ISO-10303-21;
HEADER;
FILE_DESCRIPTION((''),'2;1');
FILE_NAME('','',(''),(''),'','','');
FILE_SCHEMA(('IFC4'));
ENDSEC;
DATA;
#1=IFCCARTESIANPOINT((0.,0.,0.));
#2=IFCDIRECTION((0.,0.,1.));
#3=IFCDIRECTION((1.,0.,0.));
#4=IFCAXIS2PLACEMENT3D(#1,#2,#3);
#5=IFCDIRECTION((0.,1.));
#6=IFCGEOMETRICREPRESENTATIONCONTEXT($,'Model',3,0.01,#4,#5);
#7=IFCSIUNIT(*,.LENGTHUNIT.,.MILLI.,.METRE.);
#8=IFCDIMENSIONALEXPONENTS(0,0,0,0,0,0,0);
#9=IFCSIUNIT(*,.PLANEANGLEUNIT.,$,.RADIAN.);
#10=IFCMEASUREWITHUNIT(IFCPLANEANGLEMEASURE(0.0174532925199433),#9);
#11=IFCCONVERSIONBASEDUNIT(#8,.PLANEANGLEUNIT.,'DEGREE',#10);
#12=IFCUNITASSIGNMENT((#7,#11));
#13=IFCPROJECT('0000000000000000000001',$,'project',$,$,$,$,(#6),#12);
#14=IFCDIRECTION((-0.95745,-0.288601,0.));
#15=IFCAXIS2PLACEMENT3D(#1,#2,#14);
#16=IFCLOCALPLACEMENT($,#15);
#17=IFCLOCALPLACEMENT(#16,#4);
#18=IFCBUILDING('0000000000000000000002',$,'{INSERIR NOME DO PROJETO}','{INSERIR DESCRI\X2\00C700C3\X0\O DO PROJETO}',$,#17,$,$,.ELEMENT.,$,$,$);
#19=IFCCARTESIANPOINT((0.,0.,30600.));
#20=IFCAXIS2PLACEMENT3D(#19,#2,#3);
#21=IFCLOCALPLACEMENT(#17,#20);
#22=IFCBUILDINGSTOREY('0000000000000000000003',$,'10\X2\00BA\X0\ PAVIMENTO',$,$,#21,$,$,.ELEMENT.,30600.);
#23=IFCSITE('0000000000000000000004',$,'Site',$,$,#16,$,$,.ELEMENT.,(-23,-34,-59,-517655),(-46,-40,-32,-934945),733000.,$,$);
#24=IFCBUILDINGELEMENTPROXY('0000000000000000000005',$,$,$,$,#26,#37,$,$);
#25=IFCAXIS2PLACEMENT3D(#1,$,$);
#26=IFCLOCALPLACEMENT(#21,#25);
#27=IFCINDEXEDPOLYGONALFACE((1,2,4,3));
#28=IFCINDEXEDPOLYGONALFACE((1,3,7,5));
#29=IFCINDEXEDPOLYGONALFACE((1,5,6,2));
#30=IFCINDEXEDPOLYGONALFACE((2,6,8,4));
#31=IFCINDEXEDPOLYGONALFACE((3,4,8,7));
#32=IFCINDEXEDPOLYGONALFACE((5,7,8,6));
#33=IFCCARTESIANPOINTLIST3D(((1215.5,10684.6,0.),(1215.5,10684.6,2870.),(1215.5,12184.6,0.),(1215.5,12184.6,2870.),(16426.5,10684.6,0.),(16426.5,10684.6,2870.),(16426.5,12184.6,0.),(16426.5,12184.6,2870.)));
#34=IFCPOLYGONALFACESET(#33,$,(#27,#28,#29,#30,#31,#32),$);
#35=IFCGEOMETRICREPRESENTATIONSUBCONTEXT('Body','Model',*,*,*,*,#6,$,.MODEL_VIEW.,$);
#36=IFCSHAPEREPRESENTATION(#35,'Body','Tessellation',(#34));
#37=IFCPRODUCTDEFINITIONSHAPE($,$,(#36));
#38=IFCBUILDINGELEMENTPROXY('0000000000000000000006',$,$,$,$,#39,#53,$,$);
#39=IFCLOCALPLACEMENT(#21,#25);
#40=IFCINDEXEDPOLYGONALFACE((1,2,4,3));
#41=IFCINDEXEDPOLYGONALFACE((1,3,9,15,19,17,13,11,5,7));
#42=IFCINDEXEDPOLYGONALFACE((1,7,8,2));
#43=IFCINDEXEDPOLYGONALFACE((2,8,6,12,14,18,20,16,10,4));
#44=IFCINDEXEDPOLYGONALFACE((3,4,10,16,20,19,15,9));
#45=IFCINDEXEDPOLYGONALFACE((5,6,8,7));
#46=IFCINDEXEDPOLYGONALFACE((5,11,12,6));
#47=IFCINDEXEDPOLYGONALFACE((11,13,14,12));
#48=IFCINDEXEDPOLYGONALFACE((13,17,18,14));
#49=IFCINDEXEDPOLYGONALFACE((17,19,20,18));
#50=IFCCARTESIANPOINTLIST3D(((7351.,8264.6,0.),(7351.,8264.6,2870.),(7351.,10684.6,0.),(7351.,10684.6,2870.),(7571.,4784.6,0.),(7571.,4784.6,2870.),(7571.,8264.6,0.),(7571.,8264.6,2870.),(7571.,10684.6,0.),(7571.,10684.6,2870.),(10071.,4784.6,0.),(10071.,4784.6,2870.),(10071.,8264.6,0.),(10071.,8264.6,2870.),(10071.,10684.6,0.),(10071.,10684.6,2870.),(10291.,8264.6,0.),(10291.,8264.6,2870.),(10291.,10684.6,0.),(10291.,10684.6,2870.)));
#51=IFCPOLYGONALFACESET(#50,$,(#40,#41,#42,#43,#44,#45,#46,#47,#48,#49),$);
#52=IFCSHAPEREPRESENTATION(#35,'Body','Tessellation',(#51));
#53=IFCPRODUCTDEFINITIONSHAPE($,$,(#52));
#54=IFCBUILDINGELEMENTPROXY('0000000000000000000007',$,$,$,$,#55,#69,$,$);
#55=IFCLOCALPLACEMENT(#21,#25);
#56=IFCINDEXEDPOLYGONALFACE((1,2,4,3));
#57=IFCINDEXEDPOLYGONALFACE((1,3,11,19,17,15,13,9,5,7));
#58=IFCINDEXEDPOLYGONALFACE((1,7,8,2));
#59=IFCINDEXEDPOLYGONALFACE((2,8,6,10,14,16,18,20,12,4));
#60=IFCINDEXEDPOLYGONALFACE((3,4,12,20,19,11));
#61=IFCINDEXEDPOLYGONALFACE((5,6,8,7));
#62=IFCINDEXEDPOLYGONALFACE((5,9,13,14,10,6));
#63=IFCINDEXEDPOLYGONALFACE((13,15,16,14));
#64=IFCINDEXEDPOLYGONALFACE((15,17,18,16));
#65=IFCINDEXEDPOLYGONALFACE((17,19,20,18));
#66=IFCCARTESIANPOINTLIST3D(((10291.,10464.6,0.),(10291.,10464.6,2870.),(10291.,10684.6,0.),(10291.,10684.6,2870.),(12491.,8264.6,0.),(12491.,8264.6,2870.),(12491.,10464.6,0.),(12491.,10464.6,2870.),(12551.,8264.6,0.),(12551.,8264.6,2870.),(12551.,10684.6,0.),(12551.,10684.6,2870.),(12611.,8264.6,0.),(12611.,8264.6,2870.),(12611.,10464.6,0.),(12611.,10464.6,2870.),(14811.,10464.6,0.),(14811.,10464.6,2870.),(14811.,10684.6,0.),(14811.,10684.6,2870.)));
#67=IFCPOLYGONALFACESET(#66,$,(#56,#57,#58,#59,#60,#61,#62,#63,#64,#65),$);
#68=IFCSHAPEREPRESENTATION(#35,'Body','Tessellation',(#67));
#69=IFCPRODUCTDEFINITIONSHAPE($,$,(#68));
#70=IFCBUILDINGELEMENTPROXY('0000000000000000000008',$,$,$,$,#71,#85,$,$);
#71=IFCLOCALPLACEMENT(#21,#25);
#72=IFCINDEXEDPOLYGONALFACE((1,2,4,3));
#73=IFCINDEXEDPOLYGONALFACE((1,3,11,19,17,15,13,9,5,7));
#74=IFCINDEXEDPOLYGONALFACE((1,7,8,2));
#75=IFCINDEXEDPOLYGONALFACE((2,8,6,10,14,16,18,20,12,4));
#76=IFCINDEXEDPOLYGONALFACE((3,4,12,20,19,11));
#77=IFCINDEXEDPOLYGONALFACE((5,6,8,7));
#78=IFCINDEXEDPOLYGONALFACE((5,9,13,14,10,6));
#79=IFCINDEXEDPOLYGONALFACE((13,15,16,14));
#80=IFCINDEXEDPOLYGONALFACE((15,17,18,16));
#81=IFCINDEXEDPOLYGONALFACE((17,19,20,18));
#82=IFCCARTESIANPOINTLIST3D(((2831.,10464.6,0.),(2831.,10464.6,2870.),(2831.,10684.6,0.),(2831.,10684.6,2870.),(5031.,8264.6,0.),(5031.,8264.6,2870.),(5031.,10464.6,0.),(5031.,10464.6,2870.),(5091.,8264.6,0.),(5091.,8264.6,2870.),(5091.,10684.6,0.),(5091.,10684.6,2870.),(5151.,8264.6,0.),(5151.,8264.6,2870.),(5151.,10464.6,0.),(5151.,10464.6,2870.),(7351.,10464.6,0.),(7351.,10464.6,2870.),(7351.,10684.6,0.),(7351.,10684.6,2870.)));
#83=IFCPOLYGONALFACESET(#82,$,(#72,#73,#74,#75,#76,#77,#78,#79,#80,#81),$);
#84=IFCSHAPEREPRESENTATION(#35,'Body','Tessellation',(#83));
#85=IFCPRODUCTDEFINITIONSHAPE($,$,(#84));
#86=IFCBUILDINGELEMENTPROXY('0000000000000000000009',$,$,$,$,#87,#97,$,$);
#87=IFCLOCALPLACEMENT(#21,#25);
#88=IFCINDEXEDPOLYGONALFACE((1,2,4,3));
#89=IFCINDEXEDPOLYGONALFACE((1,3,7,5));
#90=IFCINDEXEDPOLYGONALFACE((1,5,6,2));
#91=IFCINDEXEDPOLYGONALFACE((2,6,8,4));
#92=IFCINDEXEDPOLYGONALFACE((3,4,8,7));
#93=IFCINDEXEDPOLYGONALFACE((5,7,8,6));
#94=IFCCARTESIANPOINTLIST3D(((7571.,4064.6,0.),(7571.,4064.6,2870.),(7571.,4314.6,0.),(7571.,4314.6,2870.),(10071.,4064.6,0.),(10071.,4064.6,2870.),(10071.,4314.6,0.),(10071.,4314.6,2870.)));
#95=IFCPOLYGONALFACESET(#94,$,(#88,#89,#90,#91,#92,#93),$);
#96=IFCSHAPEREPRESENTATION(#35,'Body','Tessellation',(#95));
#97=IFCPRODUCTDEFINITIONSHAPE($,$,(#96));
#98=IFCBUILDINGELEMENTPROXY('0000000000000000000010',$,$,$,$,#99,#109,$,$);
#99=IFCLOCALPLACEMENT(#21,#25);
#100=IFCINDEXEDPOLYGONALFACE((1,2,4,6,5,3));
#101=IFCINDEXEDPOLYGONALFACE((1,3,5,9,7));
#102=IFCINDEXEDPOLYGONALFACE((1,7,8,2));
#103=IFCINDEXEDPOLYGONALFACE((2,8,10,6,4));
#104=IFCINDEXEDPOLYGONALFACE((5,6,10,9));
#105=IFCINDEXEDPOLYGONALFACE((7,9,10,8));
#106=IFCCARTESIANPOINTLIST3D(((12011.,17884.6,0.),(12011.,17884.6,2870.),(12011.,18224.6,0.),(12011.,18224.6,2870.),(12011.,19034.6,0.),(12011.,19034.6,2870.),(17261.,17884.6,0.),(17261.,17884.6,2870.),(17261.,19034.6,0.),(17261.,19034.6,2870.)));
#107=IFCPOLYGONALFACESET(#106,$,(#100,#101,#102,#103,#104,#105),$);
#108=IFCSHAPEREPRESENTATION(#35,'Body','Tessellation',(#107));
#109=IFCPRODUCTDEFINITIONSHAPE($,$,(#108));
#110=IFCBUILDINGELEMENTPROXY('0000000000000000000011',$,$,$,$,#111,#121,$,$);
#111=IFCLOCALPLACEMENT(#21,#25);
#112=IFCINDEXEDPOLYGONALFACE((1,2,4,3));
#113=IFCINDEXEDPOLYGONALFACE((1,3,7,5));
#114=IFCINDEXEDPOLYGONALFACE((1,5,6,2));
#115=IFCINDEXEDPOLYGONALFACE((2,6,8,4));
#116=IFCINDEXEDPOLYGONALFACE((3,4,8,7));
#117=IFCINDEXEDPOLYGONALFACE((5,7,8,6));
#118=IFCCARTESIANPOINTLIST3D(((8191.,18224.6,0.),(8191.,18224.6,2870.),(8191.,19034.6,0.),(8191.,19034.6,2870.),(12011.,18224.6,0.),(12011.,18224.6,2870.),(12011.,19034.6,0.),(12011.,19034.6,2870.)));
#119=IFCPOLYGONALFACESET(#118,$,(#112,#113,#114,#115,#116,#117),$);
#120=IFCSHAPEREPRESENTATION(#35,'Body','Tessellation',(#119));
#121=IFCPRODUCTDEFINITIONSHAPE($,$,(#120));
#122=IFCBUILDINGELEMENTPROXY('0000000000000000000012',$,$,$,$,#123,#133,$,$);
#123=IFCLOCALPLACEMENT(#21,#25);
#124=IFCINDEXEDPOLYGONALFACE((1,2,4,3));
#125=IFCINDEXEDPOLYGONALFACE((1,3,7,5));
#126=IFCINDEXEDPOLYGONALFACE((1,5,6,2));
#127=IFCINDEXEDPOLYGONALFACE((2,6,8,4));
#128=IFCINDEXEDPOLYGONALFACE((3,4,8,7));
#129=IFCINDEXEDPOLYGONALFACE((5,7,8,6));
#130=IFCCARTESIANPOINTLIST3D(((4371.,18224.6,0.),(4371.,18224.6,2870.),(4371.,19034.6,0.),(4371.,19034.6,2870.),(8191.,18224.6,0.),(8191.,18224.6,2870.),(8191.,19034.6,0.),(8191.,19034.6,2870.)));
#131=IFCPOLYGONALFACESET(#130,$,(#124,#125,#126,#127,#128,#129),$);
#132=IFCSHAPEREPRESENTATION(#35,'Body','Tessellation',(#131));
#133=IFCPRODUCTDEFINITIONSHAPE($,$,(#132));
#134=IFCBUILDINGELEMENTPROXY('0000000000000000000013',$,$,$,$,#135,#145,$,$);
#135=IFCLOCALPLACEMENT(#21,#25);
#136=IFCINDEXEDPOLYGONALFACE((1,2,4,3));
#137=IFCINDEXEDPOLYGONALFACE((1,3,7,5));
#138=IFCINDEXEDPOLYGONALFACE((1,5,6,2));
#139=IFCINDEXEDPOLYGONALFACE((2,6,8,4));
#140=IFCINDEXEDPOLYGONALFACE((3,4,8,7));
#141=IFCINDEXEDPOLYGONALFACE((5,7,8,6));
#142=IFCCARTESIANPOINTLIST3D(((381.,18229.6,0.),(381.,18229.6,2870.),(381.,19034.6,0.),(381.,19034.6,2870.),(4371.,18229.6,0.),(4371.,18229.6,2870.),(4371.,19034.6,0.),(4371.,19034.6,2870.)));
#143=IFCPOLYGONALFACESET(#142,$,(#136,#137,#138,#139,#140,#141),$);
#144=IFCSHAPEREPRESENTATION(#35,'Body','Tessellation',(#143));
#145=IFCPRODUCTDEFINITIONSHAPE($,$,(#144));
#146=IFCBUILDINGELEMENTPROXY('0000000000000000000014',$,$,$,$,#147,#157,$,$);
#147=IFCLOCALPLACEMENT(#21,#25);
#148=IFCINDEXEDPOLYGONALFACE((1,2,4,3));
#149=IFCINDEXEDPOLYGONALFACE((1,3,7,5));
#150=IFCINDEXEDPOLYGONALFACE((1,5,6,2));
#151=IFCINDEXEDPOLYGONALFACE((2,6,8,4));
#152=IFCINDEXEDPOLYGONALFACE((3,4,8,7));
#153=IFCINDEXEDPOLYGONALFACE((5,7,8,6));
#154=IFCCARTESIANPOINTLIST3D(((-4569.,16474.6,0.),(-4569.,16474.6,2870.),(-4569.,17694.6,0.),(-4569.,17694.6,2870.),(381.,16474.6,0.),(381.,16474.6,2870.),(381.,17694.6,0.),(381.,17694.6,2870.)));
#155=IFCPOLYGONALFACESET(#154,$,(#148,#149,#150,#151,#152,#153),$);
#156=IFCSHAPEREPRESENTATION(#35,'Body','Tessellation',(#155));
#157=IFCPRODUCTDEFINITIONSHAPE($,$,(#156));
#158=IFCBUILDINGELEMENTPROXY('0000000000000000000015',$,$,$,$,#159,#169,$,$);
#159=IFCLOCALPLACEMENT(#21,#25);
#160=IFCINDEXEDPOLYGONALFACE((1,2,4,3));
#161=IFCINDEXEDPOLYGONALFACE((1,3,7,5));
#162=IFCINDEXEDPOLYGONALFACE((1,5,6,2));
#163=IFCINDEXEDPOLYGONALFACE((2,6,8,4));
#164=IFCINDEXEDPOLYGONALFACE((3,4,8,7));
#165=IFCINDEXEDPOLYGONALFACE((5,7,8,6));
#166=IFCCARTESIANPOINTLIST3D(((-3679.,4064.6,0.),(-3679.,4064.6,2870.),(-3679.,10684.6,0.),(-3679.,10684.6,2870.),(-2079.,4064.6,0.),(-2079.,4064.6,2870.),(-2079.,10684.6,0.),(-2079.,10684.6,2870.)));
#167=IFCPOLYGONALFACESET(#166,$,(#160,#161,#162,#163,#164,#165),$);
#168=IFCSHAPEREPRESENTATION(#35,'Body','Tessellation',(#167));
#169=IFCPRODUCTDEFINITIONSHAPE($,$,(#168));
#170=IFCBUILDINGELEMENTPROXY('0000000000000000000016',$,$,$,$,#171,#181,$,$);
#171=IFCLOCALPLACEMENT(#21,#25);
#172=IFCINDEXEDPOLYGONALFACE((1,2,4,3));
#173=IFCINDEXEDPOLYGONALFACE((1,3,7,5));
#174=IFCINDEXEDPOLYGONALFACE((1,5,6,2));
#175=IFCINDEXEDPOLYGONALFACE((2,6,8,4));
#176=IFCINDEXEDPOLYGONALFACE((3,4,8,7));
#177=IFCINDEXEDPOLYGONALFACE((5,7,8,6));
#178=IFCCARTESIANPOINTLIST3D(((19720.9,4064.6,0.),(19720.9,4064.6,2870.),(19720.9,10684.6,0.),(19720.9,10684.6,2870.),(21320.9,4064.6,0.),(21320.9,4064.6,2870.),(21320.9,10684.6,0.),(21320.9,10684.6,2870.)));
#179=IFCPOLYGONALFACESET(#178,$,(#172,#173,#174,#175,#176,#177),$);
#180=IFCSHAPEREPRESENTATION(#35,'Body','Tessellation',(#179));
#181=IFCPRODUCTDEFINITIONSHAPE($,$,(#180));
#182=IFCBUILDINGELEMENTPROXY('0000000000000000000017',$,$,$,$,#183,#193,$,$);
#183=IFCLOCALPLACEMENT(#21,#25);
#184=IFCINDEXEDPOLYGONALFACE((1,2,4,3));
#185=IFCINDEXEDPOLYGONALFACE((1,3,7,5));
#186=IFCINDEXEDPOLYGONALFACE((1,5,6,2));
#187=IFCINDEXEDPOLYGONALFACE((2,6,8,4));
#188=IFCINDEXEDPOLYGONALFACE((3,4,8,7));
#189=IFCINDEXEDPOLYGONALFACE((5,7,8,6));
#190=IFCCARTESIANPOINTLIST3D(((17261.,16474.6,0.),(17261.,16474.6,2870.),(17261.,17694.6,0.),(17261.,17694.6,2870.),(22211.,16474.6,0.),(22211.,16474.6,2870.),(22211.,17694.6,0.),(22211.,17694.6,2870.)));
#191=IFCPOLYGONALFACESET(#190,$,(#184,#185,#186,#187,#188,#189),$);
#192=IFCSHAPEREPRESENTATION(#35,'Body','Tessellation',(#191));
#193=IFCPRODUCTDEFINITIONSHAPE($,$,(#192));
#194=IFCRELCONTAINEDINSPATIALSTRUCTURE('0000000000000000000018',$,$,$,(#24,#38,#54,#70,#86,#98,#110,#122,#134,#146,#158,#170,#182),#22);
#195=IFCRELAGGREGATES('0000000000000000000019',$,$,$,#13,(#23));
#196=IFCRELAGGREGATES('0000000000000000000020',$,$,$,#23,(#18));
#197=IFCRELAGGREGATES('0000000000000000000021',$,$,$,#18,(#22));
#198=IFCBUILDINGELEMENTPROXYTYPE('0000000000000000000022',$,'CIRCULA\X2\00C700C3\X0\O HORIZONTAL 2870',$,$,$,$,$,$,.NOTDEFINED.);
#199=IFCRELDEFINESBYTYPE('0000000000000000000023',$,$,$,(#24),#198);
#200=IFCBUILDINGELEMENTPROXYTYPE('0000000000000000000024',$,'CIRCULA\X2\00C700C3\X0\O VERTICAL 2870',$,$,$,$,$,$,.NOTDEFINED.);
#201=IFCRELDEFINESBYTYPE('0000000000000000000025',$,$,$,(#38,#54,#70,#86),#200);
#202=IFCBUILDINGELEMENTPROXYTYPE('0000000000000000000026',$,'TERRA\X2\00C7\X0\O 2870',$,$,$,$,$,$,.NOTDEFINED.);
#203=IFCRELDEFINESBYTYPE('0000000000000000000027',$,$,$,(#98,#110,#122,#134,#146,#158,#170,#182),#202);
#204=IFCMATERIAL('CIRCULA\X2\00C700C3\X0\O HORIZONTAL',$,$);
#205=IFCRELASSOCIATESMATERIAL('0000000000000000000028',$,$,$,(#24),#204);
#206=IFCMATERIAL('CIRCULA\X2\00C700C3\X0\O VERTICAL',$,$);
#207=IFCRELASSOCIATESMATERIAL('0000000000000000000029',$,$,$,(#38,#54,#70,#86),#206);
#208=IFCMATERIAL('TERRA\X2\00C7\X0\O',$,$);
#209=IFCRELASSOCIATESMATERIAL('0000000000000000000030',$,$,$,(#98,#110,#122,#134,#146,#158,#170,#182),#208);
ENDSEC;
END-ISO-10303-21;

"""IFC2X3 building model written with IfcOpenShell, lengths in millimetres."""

from ifc_helpers import new_model, entity, si_unit, converted_unit, direction, frame, origin_with_axes, place, context, subcontext, project, spatial, polyline, outline, extrude, material, type_object, element, save


model = new_model("IFC2X3")

# Units and contexts
model_context = context("Model", 3, precision=0.01, world=origin_with_axes(), true_north=direction((0.0, 1.0)))
body_context = subcontext(model_context, "Body", "Model", "MODEL_VIEW")
ifc_project = project(units=[si_unit("LENGTHUNIT", "METRE", prefix="MILLI"), converted_unit("PLANEANGLEUNIT", "DEGREE", entity("IfcPlaneAngleMeasure", 0.0174532925199433), si_unit("PLANEANGLEUNIT", "RADIAN"), dimensions=[0, 0, 0, 0, 0, 0, 0])], contexts=[model_context])

# Site, building, storey
site_placement = place(None, frame((0.0, 0.0, 0.0), z_axis=(0.0, 0.0, 1.0), x_axis=(-0.95745, -0.288601, 0.0)))
site = spatial("IfcSite", under=ifc_project, at=site_placement, Name="Site", CompositionType="ELEMENT", RefLatitude=(-23, -34, -59, -517655), RefLongitude=(-46, -40, -32, -934945), RefElevation=733000.0)
building_placement = place(site_placement, origin_with_axes())
building = spatial("IfcBuilding", under=site, at=building_placement, Name="{INSERIR NOME DO PROJETO}", Description="{INSERIR DESCRIÇÃO DO PROJETO}", CompositionType="ELEMENT")
storey_placement = place(building_placement, frame((0.0, 0.0, 30600.0), z_axis=(0.0, 0.0, 1.0), x_axis=(1.0, 0.0, 0.0)))
storey = spatial("IfcBuildingStorey", under=building, at=storey_placement, Name="10º PAVIMENTO", CompositionType="ELEMENT", Elevation=30600.0)

# Building element proxies
ifc_material_1 = material(Name="CIRCULAÇÃO HORIZONTAL")
building_element_proxy_type_1 = type_object("IfcBuildingElementProxyType", Name="CIRCULAÇÃO HORIZONTAL 2870", PredefinedType="NOTDEFINED")
proxy_1_placement = place(storey_placement, frame((1215.5, 10684.6, 0.0), z_axis=(0.0, 0.0, 1.0), x_axis=(1.0, 0.0, 0.0)))
element("IfcBuildingElementProxy", 1, at=proxy_1_placement, inside=storey, type_object=building_element_proxy_type_1, material=ifc_material_1, context=body_context, shape_type="SweptSolid", body=[
    extrude(outline(polyline([(0.0, 0.0), (15211.0, 0.0), (15211.0, 1500.0), (0.0, 1500.0), (0.0, 0.0)])), origin_with_axes(), (0.0, 0.0, 1.0), 2870.0),
])
ifc_material_2 = material(Name="CIRCULAÇÃO VERTICAL")
building_element_proxy_type_2 = type_object("IfcBuildingElementProxyType", Name="CIRCULAÇÃO VERTICAL 2870", PredefinedType="NOTDEFINED")
proxy_2_placement = place(storey_placement, frame((7351.0, 10684.6, 0.0), z_axis=(0.0, 0.0, 1.0), x_axis=(1.0, 0.0, 0.0)))
element("IfcBuildingElementProxy", 2, at=proxy_2_placement, inside=storey, type_object=building_element_proxy_type_2, material=ifc_material_2, context=body_context, shape_type="SweptSolid", body=[
    extrude(outline(polyline([(0.0, 0.0), (0.0, -2420.0), (220.0, -2420.0), (220.0, -5900.0), (2720.0, -5900.0), (2720.0, -2420.0), (2940.0, -2420.0), (2940.0, 0.0), (2720.0, 0.0), (220.0, 0.0), (0.0, 0.0)])), origin_with_axes(), (0.0, 0.0, 1.0), 2870.0),
])
proxy_3_placement = place(storey_placement, frame((10291.0, 10684.6, 0.0), z_axis=(0.0, 0.0, 1.0), x_axis=(1.0, 0.0, 0.0)))
element("IfcBuildingElementProxy", 3, at=proxy_3_placement, inside=storey, type_object=building_element_proxy_type_2, material=ifc_material_2, context=body_context, shape_type="SweptSolid", body=[
    extrude(outline(polyline([(0.0, 0.0), (0.0, -220.0), (2200.0, -220.0), (2200.0, -2420.0), (2260.0, -2420.0), (2320.0, -2420.0), (2320.0, -220.0), (4520.0, -220.0), (4520.0, 0.0), (2260.0, 0.0), (0.0, 0.0)])), origin_with_axes(), (0.0, 0.0, 1.0), 2870.0),
])
proxy_4_placement = place(storey_placement, frame((5091.0, 10684.6, 0.0), z_axis=(0.0, 0.0, 1.0), x_axis=(1.0, 0.0, 0.0)))
element("IfcBuildingElementProxy", 4, at=proxy_4_placement, inside=storey, type_object=building_element_proxy_type_2, material=ifc_material_2, context=body_context, shape_type="SweptSolid", body=[
    extrude(outline(polyline([(0.0, 0.0), (-2260.0, 0.0), (-2260.0, -220.0), (-60.0, -220.0), (-60.0, -2420.0), (0.0, -2420.0), (60.0, -2420.0), (60.0, -220.0), (2260.0, -220.0), (2260.0, 0.0), (0.0, 0.0)])), origin_with_axes(), (0.0, 0.0, 1.0), 2870.0),
])
proxy_5_placement = place(storey_placement, frame((7571.0, 4064.6, 0.0), z_axis=(0.0, 0.0, 1.0), x_axis=(1.0, 0.0, 0.0)))
element("IfcBuildingElementProxy", 5, at=proxy_5_placement, inside=storey, type_object=building_element_proxy_type_2, material=ifc_material_2, context=body_context, shape_type="SweptSolid", body=[
    extrude(outline(polyline([(0.0, 0.0), (2500.0, 0.0), (2500.0, 250.0), (0.0, 250.0), (0.0, 0.0)])), origin_with_axes(), (0.0, 0.0, 1.0), 2870.0),
])
ifc_material_3 = material(Name="TERRAÇO")
building_element_proxy_type_3 = type_object("IfcBuildingElementProxyType", Name="TERRAÇO 2870", PredefinedType="NOTDEFINED")
proxy_6_placement = place(storey_placement, frame((12011.0, 19034.6, 0.0), z_axis=(0.0, 0.0, 1.0), x_axis=(1.0, 0.0, 0.0)))
element("IfcBuildingElementProxy", 6, at=proxy_6_placement, inside=storey, type_object=building_element_proxy_type_3, material=ifc_material_3, context=body_context, shape_type="SweptSolid", body=[
    extrude(outline(polyline([(0.0, 0.0), (0.0, -810.0), (0.0, -1150.0), (5250.0, -1150.0), (5250.0, 0.0), (0.0, 0.0)])), origin_with_axes(), (0.0, 0.0, 1.0), 2870.0),
])
for number, where, z_axis, x_axis in (
    (7, (8191.0, 18224.6, 0.0), (0.0, 0.0, 1.0), (1.0, 0.0, 0.0)),
    (8, (4371.0, 18224.6, 0.0), (0.0, 0.0, 1.0), (1.0, 0.0, 0.0)),
):
    element("IfcBuildingElementProxy", number, at=place(storey_placement, frame(where, z_axis=z_axis, x_axis=x_axis)), inside=storey, type_object=building_element_proxy_type_3, material=ifc_material_3, context=body_context, shape_type="SweptSolid", body=[
        extrude(outline(polyline([(0.0, 0.0), (3820.0, 0.0), (3820.0, 810.0), (0.0, 810.0), (0.0, 0.0)])), origin_with_axes(), (0.0, 0.0, 1.0), 2870.0),
    ])
proxy_7_placement = place(storey_placement, frame((381.0, 19034.6, 0.0), z_axis=(0.0, 0.0, 1.0), x_axis=(1.0, 0.0, 0.0)))
element("IfcBuildingElementProxy", 9, at=proxy_7_placement, inside=storey, type_object=building_element_proxy_type_3, material=ifc_material_3, context=body_context, shape_type="SweptSolid", body=[
    extrude(outline(polyline([(0.0, 0.0), (0.0, -805.0), (3990.0, -805.0), (3990.0, 0.0), (0.0, 0.0)])), origin_with_axes(), (0.0, 0.0, 1.0), 2870.0),
])
proxy_8_placement = place(storey_placement, frame((381.0, 17694.6, 0.0), z_axis=(0.0, 0.0, 1.0), x_axis=(1.0, 0.0, 0.0)))
element("IfcBuildingElementProxy", 10, at=proxy_8_placement, inside=storey, type_object=building_element_proxy_type_3, material=ifc_material_3, context=body_context, shape_type="SweptSolid", body=[
    extrude(outline(polyline([(0.0, 0.0), (-4950.0, 0.0), (-4950.0, -1220.0), (0.0, -1220.0), (0.0, 0.0)])), origin_with_axes(), (0.0, 0.0, 1.0), 2870.0),
])
proxy_9_placement = place(storey_placement, frame((-3679.0, 4064.6, 0.0), z_axis=(0.0, 0.0, 1.0), x_axis=(1.0, 0.0, 0.0)))
element("IfcBuildingElementProxy", 11, at=proxy_9_placement, inside=storey, type_object=building_element_proxy_type_3, material=ifc_material_3, context=body_context, shape_type="SweptSolid", body=[
    extrude(outline(polyline([(0.0, 0.0), (1600.0, 0.0), (1600.0, 6620.0), (0.0, 6620.0), (0.0, 0.0)])), origin_with_axes(), (0.0, 0.0, 1.0), 2870.0),
])
proxy_10_placement = place(storey_placement, frame((21320.9, 4064.6, 0.0), z_axis=(0.0, 0.0, 1.0), x_axis=(1.0, 0.0, 0.0)))
element("IfcBuildingElementProxy", 12, at=proxy_10_placement, inside=storey, type_object=building_element_proxy_type_3, material=ifc_material_3, context=body_context, shape_type="SweptSolid", body=[
    extrude(outline(polyline([(0.0, 0.0), (0.0, 6620.0), (-1600.0, 6620.0), (-1600.0, 0.0), (0.0, 0.0)])), origin_with_axes(), (0.0, 0.0, 1.0), 2870.0),
])
proxy_11_placement = place(storey_placement, frame((17261.0, 16474.6, 0.0), z_axis=(0.0, 0.0, 1.0), x_axis=(1.0, 0.0, 0.0)))
element("IfcBuildingElementProxy", 13, at=proxy_11_placement, inside=storey, type_object=building_element_proxy_type_3, material=ifc_material_3, context=body_context, shape_type="SweptSolid", body=[
    extrude(outline(polyline([(0.0, 0.0), (4950.0, 0.0), (4950.0, 1220.0), (0.0, 1220.0), (0.0, 0.0)])), origin_with_axes(), (0.0, 0.0, 1.0), 2870.0),
])

save(model, "model.ifc")
